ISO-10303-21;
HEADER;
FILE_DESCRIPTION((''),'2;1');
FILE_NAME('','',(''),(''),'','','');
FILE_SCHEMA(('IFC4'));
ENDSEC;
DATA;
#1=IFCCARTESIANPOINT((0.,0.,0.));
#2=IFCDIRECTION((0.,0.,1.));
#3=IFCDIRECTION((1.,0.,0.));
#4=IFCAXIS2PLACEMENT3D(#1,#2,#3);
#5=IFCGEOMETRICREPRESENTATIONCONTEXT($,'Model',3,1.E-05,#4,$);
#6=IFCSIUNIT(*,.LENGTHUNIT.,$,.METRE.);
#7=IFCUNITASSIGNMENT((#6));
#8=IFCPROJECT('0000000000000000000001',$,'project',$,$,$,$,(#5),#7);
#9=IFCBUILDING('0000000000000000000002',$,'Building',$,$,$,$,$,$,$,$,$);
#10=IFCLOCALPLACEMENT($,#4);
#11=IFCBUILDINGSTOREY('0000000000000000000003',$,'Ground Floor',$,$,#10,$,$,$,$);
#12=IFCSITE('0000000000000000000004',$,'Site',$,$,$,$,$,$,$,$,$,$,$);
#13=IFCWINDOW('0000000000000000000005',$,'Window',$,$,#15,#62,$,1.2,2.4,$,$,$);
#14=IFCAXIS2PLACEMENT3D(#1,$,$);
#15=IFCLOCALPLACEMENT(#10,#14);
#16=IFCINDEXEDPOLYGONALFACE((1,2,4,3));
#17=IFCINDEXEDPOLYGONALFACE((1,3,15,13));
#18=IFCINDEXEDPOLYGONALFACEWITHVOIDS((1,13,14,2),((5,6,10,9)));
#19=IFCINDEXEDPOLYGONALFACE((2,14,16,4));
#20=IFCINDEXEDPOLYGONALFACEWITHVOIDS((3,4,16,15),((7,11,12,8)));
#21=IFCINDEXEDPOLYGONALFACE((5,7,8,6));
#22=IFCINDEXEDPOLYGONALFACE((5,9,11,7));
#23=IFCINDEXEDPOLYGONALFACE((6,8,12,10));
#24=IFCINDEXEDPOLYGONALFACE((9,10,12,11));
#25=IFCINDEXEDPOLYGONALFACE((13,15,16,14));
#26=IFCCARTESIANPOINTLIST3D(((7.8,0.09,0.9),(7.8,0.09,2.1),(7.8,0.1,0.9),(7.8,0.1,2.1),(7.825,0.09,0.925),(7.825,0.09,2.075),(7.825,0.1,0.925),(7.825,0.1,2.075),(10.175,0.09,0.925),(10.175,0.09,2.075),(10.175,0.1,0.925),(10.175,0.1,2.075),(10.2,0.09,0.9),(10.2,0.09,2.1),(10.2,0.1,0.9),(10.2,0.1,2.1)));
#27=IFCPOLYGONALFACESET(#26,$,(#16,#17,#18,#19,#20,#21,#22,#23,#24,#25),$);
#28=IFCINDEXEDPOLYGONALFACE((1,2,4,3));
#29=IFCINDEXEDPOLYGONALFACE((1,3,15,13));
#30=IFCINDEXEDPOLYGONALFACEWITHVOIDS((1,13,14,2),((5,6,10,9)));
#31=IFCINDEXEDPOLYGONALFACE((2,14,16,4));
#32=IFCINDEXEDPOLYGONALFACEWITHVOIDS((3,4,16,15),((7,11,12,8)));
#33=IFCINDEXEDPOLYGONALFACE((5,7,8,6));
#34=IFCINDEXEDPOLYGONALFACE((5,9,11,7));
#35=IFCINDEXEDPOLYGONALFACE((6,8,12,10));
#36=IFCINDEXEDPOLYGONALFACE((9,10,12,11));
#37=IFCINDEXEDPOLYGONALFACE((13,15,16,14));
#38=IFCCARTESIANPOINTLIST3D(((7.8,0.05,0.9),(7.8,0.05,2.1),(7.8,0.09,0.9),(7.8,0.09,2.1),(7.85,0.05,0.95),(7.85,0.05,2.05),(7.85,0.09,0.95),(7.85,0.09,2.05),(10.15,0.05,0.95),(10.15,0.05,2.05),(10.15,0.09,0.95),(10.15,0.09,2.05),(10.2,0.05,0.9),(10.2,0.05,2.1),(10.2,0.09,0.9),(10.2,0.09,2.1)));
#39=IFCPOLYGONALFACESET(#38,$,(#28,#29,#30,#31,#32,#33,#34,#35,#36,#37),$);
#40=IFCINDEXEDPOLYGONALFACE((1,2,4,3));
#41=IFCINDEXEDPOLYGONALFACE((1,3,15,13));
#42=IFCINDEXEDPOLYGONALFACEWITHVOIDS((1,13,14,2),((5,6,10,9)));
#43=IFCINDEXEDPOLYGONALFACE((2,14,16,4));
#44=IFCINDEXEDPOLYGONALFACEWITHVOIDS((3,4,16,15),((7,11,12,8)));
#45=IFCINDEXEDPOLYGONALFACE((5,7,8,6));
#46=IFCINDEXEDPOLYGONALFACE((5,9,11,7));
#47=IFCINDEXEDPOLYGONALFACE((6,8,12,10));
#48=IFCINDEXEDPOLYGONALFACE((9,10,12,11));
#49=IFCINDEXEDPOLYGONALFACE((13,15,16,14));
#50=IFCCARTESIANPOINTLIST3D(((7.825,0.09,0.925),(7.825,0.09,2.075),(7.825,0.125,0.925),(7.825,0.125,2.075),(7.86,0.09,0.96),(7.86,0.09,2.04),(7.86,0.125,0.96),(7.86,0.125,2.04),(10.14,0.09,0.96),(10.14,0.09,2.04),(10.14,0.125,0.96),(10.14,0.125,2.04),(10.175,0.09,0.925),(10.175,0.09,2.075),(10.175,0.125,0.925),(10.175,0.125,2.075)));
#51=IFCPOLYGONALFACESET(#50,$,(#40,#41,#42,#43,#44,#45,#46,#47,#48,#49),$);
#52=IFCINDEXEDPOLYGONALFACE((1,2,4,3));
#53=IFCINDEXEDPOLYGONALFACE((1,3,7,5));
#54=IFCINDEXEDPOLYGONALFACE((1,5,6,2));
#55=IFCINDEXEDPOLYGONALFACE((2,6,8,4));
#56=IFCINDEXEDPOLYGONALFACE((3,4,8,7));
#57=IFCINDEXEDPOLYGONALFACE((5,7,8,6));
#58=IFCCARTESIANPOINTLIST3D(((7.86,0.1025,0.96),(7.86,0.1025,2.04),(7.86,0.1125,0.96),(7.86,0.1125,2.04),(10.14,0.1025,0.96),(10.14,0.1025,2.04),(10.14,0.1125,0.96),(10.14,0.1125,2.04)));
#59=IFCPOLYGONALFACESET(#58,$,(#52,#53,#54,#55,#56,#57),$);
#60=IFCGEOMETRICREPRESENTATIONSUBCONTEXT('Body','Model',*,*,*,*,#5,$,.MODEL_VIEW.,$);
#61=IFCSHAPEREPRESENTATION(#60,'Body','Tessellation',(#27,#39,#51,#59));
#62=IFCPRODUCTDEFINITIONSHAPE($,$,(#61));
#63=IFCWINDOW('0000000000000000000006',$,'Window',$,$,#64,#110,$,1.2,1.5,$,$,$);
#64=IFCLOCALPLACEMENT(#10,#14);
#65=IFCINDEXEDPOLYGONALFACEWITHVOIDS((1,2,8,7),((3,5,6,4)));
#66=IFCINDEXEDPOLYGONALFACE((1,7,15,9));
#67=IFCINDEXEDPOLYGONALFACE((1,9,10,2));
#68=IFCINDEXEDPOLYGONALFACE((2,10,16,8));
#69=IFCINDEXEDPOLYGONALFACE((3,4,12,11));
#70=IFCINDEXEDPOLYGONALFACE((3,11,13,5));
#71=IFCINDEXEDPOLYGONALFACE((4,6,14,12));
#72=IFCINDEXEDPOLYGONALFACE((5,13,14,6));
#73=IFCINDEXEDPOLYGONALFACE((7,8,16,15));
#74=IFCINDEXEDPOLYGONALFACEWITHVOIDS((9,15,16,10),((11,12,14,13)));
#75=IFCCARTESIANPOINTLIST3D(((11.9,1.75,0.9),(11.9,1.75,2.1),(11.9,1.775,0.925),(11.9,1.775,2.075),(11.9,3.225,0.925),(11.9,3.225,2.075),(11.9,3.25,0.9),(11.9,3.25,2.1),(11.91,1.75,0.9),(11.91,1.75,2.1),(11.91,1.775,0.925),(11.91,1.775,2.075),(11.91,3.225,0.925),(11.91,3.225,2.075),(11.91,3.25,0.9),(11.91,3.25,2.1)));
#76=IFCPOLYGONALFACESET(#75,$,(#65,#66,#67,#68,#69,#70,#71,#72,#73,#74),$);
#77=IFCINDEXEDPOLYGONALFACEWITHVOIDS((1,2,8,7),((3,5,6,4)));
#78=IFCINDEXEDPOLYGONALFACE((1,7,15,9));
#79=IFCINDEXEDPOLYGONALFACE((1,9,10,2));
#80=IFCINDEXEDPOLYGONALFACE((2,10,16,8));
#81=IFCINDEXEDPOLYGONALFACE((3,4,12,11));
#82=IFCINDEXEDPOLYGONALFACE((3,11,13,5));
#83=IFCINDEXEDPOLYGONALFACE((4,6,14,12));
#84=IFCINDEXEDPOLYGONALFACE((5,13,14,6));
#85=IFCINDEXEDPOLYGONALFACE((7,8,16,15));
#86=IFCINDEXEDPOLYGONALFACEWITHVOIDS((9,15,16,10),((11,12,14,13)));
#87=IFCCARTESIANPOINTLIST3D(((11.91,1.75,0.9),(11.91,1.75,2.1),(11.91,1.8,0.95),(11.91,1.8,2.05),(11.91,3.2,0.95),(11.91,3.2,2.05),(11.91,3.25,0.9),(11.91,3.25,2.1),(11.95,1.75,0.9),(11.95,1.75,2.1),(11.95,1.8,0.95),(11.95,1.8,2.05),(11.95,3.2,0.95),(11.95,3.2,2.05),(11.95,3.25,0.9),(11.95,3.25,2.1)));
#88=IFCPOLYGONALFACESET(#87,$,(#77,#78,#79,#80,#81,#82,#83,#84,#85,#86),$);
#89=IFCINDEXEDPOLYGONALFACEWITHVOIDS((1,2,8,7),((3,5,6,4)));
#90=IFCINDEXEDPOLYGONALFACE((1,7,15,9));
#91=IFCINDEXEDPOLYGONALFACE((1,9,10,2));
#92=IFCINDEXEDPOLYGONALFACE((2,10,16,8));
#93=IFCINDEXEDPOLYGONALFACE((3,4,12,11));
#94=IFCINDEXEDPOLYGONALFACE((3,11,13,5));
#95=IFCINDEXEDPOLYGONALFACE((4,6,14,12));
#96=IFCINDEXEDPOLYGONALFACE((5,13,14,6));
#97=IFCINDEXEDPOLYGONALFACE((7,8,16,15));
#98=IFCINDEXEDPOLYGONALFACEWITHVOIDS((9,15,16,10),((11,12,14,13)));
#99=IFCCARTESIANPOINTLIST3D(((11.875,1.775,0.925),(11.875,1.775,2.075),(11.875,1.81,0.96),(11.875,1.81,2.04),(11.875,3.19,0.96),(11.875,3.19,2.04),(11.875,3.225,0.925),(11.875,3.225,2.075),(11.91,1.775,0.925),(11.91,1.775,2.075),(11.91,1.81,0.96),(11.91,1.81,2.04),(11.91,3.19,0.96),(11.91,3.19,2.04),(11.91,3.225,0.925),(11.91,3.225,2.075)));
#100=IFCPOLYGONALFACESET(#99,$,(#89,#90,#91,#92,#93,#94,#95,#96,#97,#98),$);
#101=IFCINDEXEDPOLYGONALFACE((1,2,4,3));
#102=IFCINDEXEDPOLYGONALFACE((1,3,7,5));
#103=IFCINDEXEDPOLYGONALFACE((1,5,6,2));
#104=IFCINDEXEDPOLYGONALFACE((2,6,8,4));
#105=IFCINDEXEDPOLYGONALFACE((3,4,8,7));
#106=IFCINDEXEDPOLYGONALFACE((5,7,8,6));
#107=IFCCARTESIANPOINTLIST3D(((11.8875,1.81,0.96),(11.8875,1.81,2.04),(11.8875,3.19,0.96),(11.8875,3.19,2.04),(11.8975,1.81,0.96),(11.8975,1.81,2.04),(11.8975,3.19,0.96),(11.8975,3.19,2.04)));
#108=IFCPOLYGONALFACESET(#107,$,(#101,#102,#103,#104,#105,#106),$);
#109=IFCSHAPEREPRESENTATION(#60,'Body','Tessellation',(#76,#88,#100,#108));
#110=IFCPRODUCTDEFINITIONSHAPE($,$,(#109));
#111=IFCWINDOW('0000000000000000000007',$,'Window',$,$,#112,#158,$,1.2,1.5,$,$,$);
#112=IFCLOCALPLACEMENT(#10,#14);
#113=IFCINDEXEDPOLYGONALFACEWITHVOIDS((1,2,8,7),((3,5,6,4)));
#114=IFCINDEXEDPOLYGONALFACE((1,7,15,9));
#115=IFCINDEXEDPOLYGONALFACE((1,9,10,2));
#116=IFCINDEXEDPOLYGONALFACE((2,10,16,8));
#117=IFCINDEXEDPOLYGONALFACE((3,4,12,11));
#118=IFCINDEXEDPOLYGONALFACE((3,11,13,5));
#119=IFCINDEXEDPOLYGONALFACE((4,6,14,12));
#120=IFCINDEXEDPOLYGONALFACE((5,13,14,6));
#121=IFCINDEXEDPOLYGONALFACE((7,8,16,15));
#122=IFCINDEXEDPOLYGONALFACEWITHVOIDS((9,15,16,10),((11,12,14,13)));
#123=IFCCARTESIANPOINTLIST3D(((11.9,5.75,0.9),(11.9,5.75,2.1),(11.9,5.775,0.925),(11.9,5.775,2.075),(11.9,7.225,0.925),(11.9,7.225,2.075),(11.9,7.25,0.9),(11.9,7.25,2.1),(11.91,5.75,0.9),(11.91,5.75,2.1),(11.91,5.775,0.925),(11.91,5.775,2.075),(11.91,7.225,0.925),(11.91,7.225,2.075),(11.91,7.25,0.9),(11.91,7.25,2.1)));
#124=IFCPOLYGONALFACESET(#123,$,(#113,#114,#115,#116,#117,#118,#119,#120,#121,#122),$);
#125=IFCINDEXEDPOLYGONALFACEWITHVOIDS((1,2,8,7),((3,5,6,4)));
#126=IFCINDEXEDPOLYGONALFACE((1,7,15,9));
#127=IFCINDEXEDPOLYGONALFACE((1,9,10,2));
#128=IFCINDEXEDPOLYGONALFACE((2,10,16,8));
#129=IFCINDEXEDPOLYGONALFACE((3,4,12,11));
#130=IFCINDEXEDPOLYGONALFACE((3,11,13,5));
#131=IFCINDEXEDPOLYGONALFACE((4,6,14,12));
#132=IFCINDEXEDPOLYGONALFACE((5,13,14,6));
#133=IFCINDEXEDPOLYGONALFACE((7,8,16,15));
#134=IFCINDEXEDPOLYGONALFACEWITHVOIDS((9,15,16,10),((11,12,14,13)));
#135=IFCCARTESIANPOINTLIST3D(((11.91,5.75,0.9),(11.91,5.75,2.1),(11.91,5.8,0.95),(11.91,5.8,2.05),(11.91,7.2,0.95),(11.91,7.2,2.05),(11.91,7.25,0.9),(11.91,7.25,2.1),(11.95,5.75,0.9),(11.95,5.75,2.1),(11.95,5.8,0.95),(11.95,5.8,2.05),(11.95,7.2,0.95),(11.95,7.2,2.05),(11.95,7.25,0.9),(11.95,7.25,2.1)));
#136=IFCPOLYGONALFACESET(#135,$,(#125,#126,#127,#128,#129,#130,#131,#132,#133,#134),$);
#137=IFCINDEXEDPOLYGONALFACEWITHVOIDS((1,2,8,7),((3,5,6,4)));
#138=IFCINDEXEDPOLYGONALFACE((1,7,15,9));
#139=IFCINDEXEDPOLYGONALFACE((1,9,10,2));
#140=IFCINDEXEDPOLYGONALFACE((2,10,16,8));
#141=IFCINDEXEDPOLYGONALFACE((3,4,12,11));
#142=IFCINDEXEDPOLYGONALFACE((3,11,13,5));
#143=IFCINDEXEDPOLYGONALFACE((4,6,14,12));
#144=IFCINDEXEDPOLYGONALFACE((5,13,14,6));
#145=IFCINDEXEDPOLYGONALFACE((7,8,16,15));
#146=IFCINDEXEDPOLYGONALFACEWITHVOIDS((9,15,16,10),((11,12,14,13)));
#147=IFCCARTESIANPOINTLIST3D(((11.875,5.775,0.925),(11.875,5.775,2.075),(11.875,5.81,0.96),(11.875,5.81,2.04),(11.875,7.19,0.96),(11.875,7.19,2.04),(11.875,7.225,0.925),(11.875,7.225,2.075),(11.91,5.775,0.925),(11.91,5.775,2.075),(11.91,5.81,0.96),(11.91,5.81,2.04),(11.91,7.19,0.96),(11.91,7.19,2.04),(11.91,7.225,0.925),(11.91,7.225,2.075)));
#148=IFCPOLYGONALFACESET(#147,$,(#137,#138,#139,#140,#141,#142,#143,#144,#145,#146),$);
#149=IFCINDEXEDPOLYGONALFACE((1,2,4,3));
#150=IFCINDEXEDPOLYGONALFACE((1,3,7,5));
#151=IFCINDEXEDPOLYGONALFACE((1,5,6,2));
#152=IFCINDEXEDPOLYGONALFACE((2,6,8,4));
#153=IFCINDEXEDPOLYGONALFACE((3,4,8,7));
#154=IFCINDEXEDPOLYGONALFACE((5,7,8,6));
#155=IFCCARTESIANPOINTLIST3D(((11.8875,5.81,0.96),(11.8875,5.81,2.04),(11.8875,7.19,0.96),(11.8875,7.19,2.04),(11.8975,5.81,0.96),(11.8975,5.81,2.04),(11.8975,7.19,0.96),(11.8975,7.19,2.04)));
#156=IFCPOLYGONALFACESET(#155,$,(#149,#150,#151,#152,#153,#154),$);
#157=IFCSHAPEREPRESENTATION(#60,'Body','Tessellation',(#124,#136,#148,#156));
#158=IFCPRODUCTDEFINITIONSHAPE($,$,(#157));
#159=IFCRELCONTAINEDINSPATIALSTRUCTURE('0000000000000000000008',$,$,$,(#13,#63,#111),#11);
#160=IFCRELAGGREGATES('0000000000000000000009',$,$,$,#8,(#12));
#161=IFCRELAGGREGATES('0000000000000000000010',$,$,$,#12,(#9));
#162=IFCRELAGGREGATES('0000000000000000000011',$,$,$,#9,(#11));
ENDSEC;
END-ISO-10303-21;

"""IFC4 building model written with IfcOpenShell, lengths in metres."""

from ifc_helpers import new_model, si_unit, frame, origin_with_axes, place, context, subcontext, project, spatial, line, indexed_curve, outline, extrude, element, save


model = new_model("IFC4")

# Units and contexts
model_context = context("Model", 3, precision=1e-05, world=origin_with_axes())
body_context = subcontext(model_context, "Body", "Model", "MODEL_VIEW")
ifc_project = project(units=[si_unit("LENGTHUNIT", "METRE")], contexts=[model_context])

# Site, building, storey
site = spatial("IfcSite", under=ifc_project, Name="Site")
building = spatial("IfcBuilding", under=site, Name="Building")
storey_placement = place(None, origin_with_axes())
storey = spatial("IfcBuildingStorey", under=building, at=storey_placement, Name="Ground Floor")

# Windows
window_placement = place(storey_placement, frame((7.8, 0.0, 0.9), z_axis=(0.0, 0.0, 1.0), x_axis=(1.0, 0.0, 0.0)))
element("IfcWindow", 1, at=window_placement, inside=storey, Name="Window", OverallHeight=1.2, OverallWidth=2.4, context=body_context, shape_type="SweptSolid", body=[
    extrude(outline(indexed_curve([(0.0, 0.0), (2.4, 0.0), (2.4, 1.2), (0.0, 1.2)], segments=[line(1, 2, 3, 4, 1)]), holes=[indexed_curve([(0.025, 0.025), (2.375, 0.025), (2.375, 1.175), (0.025, 1.175)], segments=[line(1, 2, 3, 4, 1)])]), frame((0.0, 0.09, 0.0), z_axis=(0.0, -1.0, 0.0), x_axis=(1.0, 0.0, 0.0)), (0.0, 0.0, -1.0), 0.01),
    extrude(outline(indexed_curve([(0.0, 0.0), (2.4, 0.0), (2.4, 1.2), (0.0, 1.2)], segments=[line(1, 2, 3, 4, 1)]), holes=[indexed_curve([(0.05, 0.05), (2.35, 0.05), (2.35, 1.15), (0.05, 1.15)], segments=[line(1, 2, 3, 4, 1)])]), frame((0.0, 0.05, 0.0), z_axis=(0.0, -1.0, 0.0), x_axis=(1.0, 0.0, 0.0)), (0.0, 0.0, -1.0), 0.04),
    extrude(outline(indexed_curve([(0.0, 0.0), (2.35, 0.0), (2.35, 1.15), (0.0, 1.15)], segments=[line(1, 2, 3, 4, 1)]), holes=[indexed_curve([(0.035, 0.035), (2.315, 0.035), (2.315, 1.115), (0.035, 1.115)], segments=[line(1, 2, 3, 4, 1)])]), frame((0.025, 0.09, 0.025), z_axis=(0.0, -1.0, 0.0), x_axis=(1.0, 0.0, 0.0)), (0.0, 0.0, -1.0), 0.035),
    extrude(outline(indexed_curve([(0.035, 0.035), (2.315, 0.035), (2.315, 1.115), (0.035, 1.115)], segments=[line(1, 2, 3, 4, 1)])), frame((0.025, 0.1025, 0.025), z_axis=(0.0, -1.0, 0.0), x_axis=(1.0, 0.0, 0.0)), (0.0, 0.0, -1.0), 0.01),
])
for number, where, z_axis, x_axis, name in (
    (2, (12.0, 1.75, 0.9), (0.0, 0.0, 1.0), (0.0, 1.0, 0.0), "Window"),
    (3, (12.0, 5.75, 0.9), (0.0, 0.0, 1.0), (0.0, 1.0, 0.0), "Window"),
):
    element("IfcWindow", number, at=place(storey_placement, frame(where, z_axis=z_axis, x_axis=x_axis)), inside=storey, Name=name, OverallHeight=1.2, OverallWidth=1.5, context=body_context, shape_type="SweptSolid", body=[
        extrude(outline(indexed_curve([(0.0, 0.0), (1.5, 0.0), (1.5, 1.2), (0.0, 1.2)], segments=[line(1, 2, 3, 4, 1)]), holes=[indexed_curve([(0.025, 0.025), (1.475, 0.025), (1.475, 1.175), (0.025, 1.175)], segments=[line(1, 2, 3, 4, 1)])]), frame((0.0, 0.09, 0.0), z_axis=(0.0, -1.0, 0.0), x_axis=(1.0, 0.0, 0.0)), (0.0, 0.0, -1.0), 0.01),
        extrude(outline(indexed_curve([(0.0, 0.0), (1.5, 0.0), (1.5, 1.2), (0.0, 1.2)], segments=[line(1, 2, 3, 4, 1)]), holes=[indexed_curve([(0.05, 0.05), (1.45, 0.05), (1.45, 1.15), (0.05, 1.15)], segments=[line(1, 2, 3, 4, 1)])]), frame((0.0, 0.05, 0.0), z_axis=(0.0, -1.0, 0.0), x_axis=(1.0, 0.0, 0.0)), (0.0, 0.0, -1.0), 0.04),
        extrude(outline(indexed_curve([(0.0, 0.0), (1.45, 0.0), (1.45, 1.15), (0.0, 1.15)], segments=[line(1, 2, 3, 4, 1)]), holes=[indexed_curve([(0.035, 0.035), (1.415, 0.035), (1.415, 1.115), (0.035, 1.115)], segments=[line(1, 2, 3, 4, 1)])]), frame((0.025, 0.09, 0.025), z_axis=(0.0, -1.0, 0.0), x_axis=(1.0, 0.0, 0.0)), (0.0, 0.0, -1.0), 0.035),
        extrude(outline(indexed_curve([(0.035, 0.035), (1.415, 0.035), (1.415, 1.115), (0.035, 1.115)], segments=[line(1, 2, 3, 4, 1)])), frame((0.025, 0.1025, 0.025), z_axis=(0.0, -1.0, 0.0), x_axis=(1.0, 0.0, 0.0)), (0.0, 0.0, -1.0), 0.01),
    ])

save(model, "model.ifc")
